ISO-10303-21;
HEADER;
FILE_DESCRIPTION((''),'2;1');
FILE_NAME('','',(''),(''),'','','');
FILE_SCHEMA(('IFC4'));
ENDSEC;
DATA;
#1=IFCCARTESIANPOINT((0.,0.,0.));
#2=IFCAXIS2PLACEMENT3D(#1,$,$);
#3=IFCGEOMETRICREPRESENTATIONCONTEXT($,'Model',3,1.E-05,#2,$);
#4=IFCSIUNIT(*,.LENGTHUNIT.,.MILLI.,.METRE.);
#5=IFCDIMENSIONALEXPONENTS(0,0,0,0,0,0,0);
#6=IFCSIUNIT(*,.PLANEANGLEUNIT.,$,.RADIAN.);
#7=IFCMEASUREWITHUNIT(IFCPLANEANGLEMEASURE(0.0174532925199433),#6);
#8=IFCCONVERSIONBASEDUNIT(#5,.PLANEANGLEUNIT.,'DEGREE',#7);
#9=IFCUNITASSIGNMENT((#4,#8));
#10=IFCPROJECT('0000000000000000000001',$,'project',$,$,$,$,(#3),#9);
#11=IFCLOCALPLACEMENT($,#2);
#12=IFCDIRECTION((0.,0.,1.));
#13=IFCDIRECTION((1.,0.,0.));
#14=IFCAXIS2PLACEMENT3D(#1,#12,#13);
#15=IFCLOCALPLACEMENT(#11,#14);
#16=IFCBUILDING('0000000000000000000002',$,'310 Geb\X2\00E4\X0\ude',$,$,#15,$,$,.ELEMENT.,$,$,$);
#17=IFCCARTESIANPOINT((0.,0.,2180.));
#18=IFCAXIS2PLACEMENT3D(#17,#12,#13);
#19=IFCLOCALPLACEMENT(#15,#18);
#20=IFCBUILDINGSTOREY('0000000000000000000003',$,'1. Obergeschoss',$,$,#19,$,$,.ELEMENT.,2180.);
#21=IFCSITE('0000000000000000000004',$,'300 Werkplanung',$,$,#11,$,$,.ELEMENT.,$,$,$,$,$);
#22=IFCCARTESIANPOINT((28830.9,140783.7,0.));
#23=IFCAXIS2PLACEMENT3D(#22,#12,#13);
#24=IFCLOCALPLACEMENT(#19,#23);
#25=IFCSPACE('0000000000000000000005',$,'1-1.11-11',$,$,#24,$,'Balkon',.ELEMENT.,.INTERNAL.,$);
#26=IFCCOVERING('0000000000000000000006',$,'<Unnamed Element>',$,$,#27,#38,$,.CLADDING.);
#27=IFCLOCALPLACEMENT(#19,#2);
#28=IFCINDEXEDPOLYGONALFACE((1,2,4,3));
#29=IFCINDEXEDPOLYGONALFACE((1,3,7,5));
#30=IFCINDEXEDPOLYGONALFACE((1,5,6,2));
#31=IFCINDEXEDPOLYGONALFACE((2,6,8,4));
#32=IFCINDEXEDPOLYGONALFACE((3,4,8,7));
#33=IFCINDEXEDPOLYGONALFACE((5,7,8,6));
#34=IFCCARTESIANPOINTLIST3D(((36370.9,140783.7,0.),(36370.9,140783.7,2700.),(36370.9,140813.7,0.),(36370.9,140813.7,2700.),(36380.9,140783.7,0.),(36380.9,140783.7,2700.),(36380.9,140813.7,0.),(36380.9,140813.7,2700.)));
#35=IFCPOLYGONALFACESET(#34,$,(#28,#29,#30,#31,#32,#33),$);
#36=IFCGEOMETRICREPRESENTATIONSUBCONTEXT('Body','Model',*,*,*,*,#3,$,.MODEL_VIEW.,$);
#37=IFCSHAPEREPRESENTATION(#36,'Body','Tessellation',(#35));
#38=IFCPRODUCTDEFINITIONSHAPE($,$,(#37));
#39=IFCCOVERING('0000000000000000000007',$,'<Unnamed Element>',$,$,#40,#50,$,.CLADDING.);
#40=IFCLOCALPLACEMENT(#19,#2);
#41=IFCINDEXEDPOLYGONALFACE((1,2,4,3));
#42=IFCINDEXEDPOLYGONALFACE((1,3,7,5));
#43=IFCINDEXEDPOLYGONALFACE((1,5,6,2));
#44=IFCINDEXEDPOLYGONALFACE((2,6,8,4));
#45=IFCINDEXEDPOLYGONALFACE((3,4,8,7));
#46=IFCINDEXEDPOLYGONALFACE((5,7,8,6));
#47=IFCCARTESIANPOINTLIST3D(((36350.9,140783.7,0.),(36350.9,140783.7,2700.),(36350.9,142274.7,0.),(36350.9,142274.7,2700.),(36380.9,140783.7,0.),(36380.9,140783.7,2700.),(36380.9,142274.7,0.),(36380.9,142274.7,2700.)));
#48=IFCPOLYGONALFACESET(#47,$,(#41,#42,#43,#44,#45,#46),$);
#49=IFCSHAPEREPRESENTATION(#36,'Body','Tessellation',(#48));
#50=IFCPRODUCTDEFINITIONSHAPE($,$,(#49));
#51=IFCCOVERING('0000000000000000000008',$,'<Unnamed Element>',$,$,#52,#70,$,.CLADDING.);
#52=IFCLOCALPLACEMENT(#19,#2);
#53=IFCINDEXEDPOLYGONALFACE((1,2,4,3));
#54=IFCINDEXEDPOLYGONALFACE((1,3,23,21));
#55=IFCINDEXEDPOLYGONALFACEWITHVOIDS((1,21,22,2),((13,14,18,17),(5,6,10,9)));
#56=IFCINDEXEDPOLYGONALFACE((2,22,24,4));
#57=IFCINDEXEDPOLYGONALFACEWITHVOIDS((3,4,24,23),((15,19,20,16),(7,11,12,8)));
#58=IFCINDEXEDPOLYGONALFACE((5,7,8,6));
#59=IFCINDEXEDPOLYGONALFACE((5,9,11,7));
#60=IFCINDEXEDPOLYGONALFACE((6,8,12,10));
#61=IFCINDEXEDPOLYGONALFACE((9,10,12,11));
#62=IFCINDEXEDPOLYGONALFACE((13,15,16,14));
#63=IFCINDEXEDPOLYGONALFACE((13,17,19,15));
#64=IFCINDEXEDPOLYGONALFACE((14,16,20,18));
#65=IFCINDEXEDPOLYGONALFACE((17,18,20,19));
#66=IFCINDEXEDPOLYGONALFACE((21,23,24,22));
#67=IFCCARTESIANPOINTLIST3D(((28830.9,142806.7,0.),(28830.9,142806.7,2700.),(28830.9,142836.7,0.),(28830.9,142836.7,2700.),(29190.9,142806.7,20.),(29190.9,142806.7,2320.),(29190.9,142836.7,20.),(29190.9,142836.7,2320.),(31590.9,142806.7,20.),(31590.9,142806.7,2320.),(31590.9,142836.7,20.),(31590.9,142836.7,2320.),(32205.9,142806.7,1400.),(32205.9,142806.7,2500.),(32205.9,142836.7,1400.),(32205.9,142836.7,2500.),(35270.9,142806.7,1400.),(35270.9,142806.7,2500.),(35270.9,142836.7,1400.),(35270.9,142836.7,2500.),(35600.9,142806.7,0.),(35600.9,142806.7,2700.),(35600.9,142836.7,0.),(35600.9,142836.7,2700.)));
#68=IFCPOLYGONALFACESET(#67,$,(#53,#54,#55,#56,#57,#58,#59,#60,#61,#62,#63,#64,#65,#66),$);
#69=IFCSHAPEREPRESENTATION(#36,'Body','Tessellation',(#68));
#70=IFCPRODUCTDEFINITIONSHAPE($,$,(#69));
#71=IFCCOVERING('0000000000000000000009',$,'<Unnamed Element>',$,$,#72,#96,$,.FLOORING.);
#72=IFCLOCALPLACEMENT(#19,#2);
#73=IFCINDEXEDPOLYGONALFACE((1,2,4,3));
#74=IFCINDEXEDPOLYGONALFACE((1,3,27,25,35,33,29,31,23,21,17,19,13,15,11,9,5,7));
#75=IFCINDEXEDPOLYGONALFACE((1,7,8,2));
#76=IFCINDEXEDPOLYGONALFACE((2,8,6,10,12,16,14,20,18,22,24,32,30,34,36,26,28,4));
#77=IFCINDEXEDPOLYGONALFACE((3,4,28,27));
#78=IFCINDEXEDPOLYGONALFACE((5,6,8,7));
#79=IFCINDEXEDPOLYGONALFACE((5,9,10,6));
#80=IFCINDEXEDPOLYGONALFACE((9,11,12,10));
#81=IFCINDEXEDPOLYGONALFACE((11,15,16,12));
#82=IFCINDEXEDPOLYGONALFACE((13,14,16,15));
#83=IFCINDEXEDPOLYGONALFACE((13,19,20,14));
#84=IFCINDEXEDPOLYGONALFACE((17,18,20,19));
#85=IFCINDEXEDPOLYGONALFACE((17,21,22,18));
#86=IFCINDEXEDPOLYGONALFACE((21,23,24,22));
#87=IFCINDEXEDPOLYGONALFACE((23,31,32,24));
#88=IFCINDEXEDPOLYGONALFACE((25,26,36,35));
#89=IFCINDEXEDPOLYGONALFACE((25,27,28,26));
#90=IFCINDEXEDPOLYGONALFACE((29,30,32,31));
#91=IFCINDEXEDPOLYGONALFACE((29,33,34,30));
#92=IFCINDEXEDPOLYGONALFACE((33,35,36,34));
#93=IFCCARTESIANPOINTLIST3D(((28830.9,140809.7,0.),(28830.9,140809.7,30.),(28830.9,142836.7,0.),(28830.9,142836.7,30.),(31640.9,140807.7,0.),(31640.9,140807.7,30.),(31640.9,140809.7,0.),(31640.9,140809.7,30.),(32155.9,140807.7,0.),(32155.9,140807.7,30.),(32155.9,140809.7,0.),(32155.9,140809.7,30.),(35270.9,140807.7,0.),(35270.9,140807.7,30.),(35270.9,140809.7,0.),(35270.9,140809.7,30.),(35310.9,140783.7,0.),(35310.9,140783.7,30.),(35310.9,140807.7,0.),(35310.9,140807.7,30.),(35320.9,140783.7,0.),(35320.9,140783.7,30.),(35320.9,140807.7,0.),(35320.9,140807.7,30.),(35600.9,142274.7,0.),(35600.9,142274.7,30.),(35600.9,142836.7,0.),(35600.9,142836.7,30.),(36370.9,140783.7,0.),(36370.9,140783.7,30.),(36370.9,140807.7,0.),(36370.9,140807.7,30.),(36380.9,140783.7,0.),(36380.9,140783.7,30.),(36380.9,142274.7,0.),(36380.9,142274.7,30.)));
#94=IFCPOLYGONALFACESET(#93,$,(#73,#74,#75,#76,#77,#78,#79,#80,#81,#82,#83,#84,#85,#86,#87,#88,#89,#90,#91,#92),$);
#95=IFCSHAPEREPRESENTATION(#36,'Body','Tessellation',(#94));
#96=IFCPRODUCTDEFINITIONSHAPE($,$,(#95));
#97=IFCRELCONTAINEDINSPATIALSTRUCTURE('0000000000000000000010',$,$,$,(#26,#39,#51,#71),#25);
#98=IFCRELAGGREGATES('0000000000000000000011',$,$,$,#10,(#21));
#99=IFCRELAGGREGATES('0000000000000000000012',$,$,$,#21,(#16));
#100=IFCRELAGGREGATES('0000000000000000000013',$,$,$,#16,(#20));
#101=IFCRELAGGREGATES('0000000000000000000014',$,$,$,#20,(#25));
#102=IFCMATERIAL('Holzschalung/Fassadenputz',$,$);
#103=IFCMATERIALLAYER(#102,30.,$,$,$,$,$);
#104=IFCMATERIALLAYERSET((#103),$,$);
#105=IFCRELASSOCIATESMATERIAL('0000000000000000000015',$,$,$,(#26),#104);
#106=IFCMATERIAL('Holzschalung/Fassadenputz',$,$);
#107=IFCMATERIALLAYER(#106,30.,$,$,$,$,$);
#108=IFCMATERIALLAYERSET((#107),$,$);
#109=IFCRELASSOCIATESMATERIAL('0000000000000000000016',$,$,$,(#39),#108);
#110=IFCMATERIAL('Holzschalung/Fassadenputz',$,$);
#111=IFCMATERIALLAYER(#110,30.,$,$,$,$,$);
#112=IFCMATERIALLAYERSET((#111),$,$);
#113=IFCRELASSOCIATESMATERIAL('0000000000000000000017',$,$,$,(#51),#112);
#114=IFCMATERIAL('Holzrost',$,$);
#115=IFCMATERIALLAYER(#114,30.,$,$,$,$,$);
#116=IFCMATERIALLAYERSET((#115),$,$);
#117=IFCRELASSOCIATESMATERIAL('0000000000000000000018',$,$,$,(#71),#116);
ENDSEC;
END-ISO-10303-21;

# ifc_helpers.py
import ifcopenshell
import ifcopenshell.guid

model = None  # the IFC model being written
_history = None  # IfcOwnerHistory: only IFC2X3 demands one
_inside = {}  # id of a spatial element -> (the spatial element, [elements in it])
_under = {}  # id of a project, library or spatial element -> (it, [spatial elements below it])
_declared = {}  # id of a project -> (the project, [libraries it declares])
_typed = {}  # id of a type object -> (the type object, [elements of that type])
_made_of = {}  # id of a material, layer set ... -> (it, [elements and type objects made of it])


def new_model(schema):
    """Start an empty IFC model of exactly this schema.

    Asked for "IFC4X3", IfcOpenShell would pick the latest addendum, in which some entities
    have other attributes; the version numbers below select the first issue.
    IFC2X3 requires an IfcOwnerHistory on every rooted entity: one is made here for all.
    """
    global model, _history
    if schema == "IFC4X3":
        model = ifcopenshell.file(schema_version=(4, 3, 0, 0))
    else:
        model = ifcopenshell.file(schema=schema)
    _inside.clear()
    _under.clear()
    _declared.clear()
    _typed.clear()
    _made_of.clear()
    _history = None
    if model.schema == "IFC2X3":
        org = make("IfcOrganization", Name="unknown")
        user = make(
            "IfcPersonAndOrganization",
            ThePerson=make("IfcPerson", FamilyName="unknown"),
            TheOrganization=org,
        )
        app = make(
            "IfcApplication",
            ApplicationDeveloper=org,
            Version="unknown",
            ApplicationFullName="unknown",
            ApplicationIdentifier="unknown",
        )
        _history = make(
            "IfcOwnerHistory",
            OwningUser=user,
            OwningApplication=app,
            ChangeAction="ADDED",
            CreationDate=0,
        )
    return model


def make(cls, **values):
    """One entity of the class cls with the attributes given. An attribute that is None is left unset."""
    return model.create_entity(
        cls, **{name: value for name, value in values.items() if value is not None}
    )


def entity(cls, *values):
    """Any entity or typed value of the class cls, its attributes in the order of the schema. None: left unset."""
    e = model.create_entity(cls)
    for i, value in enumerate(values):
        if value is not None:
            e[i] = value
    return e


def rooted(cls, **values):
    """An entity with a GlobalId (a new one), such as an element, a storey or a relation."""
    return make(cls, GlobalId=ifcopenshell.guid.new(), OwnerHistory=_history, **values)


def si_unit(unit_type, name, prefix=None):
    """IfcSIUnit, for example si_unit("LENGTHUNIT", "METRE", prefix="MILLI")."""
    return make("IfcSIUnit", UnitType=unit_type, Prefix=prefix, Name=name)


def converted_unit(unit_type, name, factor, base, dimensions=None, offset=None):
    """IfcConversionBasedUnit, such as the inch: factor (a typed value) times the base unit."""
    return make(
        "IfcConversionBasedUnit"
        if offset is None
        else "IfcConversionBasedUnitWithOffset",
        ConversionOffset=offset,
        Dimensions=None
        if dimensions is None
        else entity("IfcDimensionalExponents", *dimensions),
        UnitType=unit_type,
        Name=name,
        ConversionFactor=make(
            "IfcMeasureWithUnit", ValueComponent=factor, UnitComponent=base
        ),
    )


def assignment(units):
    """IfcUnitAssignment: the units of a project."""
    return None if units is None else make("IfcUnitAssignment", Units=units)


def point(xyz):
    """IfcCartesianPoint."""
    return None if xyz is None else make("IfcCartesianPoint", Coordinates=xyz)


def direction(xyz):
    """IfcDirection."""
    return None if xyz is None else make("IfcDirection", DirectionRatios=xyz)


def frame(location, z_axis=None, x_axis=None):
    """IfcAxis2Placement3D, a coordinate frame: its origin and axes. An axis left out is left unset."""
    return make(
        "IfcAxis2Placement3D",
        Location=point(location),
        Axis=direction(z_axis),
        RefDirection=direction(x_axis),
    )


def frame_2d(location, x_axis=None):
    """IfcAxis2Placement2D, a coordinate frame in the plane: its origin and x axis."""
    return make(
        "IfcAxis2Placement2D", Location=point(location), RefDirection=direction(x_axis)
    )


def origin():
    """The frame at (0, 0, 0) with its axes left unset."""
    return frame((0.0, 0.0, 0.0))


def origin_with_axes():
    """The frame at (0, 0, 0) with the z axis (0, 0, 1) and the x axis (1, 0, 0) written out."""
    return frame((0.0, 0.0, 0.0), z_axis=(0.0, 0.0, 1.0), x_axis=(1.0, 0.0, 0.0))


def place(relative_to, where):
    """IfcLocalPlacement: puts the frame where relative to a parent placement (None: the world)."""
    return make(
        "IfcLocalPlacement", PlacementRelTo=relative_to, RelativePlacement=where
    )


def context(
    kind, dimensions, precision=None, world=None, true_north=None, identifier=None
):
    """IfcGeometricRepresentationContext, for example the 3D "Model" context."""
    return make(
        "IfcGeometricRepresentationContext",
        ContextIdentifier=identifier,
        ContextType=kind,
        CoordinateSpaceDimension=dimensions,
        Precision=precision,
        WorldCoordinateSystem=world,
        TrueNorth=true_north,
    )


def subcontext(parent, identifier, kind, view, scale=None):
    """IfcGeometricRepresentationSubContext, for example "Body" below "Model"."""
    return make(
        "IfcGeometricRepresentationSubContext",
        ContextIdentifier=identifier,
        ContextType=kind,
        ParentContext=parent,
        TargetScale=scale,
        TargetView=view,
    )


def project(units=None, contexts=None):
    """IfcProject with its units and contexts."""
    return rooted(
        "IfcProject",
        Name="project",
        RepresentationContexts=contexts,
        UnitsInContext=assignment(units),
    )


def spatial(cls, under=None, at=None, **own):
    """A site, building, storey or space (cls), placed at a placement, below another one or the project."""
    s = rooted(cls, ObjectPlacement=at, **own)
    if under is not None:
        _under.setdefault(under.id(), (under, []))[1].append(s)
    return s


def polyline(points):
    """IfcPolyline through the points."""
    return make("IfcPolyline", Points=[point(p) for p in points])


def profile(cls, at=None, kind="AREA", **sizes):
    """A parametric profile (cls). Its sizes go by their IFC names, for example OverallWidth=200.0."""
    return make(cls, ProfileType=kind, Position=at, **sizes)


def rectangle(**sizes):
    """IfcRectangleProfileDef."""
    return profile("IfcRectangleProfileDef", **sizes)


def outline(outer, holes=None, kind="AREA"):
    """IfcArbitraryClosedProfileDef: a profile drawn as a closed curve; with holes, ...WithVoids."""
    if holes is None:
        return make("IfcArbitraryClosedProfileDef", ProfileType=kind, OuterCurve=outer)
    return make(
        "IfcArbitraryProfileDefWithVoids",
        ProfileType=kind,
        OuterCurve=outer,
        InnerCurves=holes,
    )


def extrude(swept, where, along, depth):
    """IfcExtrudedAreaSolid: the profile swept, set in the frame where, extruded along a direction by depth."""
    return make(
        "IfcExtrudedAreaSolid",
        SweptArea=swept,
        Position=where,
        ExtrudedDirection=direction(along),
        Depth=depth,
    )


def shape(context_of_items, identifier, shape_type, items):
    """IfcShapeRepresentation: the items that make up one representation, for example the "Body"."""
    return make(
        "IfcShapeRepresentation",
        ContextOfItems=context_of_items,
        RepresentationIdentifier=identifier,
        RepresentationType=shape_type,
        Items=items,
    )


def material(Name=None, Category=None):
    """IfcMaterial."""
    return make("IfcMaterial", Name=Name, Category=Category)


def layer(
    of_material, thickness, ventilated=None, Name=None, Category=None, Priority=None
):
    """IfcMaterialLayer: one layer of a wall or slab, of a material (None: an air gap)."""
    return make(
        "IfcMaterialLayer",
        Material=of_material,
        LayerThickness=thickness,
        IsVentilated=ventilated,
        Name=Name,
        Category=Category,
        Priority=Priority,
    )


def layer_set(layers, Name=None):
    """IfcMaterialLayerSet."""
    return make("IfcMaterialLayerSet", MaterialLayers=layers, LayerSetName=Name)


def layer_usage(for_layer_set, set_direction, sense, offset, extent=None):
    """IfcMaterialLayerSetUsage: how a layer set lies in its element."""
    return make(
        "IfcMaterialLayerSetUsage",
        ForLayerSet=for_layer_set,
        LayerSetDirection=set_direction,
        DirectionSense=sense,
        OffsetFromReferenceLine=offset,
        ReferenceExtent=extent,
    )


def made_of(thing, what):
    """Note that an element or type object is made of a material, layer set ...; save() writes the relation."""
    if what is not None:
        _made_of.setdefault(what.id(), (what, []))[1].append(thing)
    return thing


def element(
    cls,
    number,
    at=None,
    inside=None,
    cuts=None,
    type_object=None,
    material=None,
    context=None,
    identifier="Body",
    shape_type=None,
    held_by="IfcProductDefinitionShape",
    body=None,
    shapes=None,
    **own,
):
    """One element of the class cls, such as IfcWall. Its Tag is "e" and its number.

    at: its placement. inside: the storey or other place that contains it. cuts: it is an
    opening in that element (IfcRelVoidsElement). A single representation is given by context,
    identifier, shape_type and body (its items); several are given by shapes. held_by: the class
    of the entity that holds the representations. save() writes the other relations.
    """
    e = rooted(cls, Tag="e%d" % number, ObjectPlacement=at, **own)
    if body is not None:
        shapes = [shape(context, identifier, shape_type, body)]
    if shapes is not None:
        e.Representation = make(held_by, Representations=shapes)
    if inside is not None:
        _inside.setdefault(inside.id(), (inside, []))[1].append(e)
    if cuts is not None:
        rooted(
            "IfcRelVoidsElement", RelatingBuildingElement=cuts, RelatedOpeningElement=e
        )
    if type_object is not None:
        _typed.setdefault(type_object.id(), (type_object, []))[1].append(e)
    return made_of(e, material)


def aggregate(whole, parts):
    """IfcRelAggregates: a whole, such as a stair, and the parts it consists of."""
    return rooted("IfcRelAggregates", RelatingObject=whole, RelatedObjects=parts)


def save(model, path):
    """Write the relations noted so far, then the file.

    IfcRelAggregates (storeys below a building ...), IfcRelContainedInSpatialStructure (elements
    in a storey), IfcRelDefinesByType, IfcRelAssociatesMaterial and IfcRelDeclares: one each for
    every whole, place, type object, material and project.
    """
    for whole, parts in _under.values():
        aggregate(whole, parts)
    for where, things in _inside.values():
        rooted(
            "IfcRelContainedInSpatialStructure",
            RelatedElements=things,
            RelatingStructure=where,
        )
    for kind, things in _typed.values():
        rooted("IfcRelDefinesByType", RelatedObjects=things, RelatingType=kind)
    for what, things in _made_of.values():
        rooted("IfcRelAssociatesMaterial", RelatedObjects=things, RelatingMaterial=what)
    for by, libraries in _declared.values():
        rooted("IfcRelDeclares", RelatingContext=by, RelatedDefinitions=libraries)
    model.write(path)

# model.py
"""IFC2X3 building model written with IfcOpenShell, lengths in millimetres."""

from ifc_helpers import new_model, entity, si_unit, converted_unit, frame, frame_2d, origin, origin_with_axes, place, context, subcontext, project, spatial, polyline, rectangle, outline, extrude, material, layer, layer_set, layer_usage, element, save


model = new_model("IFC2X3")

# Units and contexts
model_context = context("Model", 3, precision=1e-05, world=origin())
body_context = subcontext(model_context, "Body", "Model", "MODEL_VIEW")
ifc_project = project(units=[si_unit("LENGTHUNIT", "METRE", prefix="MILLI"), converted_unit("PLANEANGLEUNIT", "DEGREE", entity("IfcPlaneAngleMeasure", 0.0174532925199433), si_unit("PLANEANGLEUNIT", "RADIAN"), dimensions=[0, 0, 0, 0, 0, 0, 0])], contexts=[model_context])

# Site, building, storey
site_placement = place(None, origin())
site = spatial("IfcSite", under=ifc_project, at=site_placement, Name="300 Werkplanung", CompositionType="ELEMENT")
building_placement = place(site_placement, origin_with_axes())
building = spatial("IfcBuilding", under=site, at=building_placement, Name="310 Gebäude", CompositionType="ELEMENT")
storey_placement = place(building_placement, frame((0.0, 0.0, 2180.0), z_axis=(0.0, 0.0, 1.0), x_axis=(1.0, 0.0, 0.0)))
storey = spatial("IfcBuildingStorey", under=building, at=storey_placement, Name="1. Obergeschoss", CompositionType="ELEMENT", Elevation=2180.0)

# Shared definitions
space_1_placement = place(storey_placement, frame((28830.9, 140783.7, 0.0), z_axis=(0.0, 0.0, 1.0), x_axis=(1.0, 0.0, 0.0)))
space_1 = spatial("IfcSpace", under=storey, at=space_1_placement, Name="1-1.11-11", LongName="Balkon", CompositionType="ELEMENT", InteriorOrExteriorSpace="INTERNAL")

# Coverings
ifc_material_1 = material(Name="Holzschalung/Fassadenputz")
ifc_layer_1 = layer(ifc_material_1, 30.0)
ifc_layer_set_1 = layer_set([ifc_layer_1])
ifc_layer_usage_1 = layer_usage(ifc_layer_set_1, "AXIS3", "POSITIVE", 0.0)
covering_1_placement = place(space_1_placement, frame((7540.0, 0.0, 0.0), z_axis=(0.0, 0.0, 1.0), x_axis=(1.0, 0.0, 0.0)))
element("IfcCovering", 1, at=covering_1_placement, inside=space_1, material=ifc_layer_usage_1, Name="<Unnamed Element>", PredefinedType="CLADDING", context=body_context, shape_type="SweptSolid", body=[
    extrude(rectangle(XDim=2700.0, YDim=10.0, at=frame_2d((-5.0, 1350.0), x_axis=(0.0, 1.0))), frame((10.0, 0.0, 2700.0), z_axis=(0.0, 1.0, 0.0), x_axis=(1.0, 0.0, 0.0)), (0.0, 0.0, 1.0), 30.0),
])
ifc_material_2 = material(Name="Holzschalung/Fassadenputz")
ifc_layer_2 = layer(ifc_material_2, 30.0)
ifc_layer_set_2 = layer_set([ifc_layer_2])
ifc_layer_usage_2 = layer_usage(ifc_layer_set_2, "AXIS3", "POSITIVE", 0.0)
covering_2_placement = place(space_1_placement, frame((7550.0, 0.0, 0.0), z_axis=(0.0, 0.0, 1.0), x_axis=(0.0, 1.0, 0.0)))
element("IfcCovering", 2, at=covering_2_placement, inside=space_1, material=ifc_layer_usage_2, Name="<Unnamed Element>", PredefinedType="CLADDING", context=body_context, shape_type="SweptSolid", body=[
    extrude(rectangle(XDim=2700.0, YDim=1491.0, at=frame_2d((-745.5, 1350.0), x_axis=(0.0, 1.0))), frame((1491.0, 0.0, 2700.0), z_axis=(0.0, 1.0, 0.0), x_axis=(1.0, 0.0, 0.0)), (0.0, 0.0, 1.0), 30.0),
])
ifc_material_3 = material(Name="Holzschalung/Fassadenputz")
ifc_layer_3 = layer(ifc_material_3, 30.0)
ifc_layer_set_3 = layer_set([ifc_layer_3])
ifc_layer_usage_3 = layer_usage(ifc_layer_set_3, "AXIS3", "POSITIVE", 0.0)
covering_3_placement = place(space_1_placement, frame((6770.0, 2053.0, 0.0), z_axis=(0.0, 0.0, 1.0), x_axis=(-1.0, 0.0, 0.0)))
element("IfcCovering", 3, at=covering_3_placement, inside=space_1, material=ifc_layer_usage_3, Name="<Unnamed Element>", PredefinedType="CLADDING", context=body_context, shape_type="SweptSolid", body=[
    extrude(outline(polyline([(6770.0, 0.0), (6770.0, -2700.0), (0.0, -2700.0), (0.0, 0.0), (6770.0, 0.0)]), holes=[polyline([(3395.0, -1400.0), (330.0, -1400.0), (330.0, -2500.0), (3395.0, -2500.0), (3395.0, -1400.0)]), polyline([(6410.0, -20.0), (4010.0, -20.0), (4010.0, -2320.0), (6410.0, -2320.0), (6410.0, -20.0)])]), frame((0.0, 0.0, 0.0), z_axis=(0.0, 1.0, 0.0), x_axis=(1.0, 0.0, 0.0)), (0.0, 0.0, 1.0), 30.0),
])
ifc_material_4 = material(Name="Holzrost")
ifc_layer_4 = layer(ifc_material_4, 30.0)
ifc_layer_set_4 = layer_set([ifc_layer_4])
ifc_layer_usage_4 = layer_usage(ifc_layer_set_4, "AXIS3", "POSITIVE", 0.0)
covering_4_placement = place(space_1_placement, origin_with_axes())
element("IfcCovering", 4, at=covering_4_placement, inside=space_1, material=ifc_layer_usage_4, Name="<Unnamed Element>", PredefinedType="FLOORING", context=body_context, shape_type="SweptSolid", body=[
    extrude(outline(polyline([(6480.0, 0.0), (6490.0, 0.0), (6490.0, 24.0), (7540.0, 24.0), (7540.0, 0.0), (7550.0, 0.0), (7550.0, 1491.0), (6770.0, 1491.0), (6770.0, 2053.0), (0.0, 2053.0), (0.0, 26.0), (2810.0, 26.0), (2810.0, 24.0), (3325.0, 24.0), (3325.0, 26.0), (6440.0, 26.0), (6440.0, 24.0), (6480.0, 24.0), (6480.0, 0.0)])), origin_with_axes(), (0.0, 0.0, 1.0), 30.0),
])

save(model, "model.ifc")
